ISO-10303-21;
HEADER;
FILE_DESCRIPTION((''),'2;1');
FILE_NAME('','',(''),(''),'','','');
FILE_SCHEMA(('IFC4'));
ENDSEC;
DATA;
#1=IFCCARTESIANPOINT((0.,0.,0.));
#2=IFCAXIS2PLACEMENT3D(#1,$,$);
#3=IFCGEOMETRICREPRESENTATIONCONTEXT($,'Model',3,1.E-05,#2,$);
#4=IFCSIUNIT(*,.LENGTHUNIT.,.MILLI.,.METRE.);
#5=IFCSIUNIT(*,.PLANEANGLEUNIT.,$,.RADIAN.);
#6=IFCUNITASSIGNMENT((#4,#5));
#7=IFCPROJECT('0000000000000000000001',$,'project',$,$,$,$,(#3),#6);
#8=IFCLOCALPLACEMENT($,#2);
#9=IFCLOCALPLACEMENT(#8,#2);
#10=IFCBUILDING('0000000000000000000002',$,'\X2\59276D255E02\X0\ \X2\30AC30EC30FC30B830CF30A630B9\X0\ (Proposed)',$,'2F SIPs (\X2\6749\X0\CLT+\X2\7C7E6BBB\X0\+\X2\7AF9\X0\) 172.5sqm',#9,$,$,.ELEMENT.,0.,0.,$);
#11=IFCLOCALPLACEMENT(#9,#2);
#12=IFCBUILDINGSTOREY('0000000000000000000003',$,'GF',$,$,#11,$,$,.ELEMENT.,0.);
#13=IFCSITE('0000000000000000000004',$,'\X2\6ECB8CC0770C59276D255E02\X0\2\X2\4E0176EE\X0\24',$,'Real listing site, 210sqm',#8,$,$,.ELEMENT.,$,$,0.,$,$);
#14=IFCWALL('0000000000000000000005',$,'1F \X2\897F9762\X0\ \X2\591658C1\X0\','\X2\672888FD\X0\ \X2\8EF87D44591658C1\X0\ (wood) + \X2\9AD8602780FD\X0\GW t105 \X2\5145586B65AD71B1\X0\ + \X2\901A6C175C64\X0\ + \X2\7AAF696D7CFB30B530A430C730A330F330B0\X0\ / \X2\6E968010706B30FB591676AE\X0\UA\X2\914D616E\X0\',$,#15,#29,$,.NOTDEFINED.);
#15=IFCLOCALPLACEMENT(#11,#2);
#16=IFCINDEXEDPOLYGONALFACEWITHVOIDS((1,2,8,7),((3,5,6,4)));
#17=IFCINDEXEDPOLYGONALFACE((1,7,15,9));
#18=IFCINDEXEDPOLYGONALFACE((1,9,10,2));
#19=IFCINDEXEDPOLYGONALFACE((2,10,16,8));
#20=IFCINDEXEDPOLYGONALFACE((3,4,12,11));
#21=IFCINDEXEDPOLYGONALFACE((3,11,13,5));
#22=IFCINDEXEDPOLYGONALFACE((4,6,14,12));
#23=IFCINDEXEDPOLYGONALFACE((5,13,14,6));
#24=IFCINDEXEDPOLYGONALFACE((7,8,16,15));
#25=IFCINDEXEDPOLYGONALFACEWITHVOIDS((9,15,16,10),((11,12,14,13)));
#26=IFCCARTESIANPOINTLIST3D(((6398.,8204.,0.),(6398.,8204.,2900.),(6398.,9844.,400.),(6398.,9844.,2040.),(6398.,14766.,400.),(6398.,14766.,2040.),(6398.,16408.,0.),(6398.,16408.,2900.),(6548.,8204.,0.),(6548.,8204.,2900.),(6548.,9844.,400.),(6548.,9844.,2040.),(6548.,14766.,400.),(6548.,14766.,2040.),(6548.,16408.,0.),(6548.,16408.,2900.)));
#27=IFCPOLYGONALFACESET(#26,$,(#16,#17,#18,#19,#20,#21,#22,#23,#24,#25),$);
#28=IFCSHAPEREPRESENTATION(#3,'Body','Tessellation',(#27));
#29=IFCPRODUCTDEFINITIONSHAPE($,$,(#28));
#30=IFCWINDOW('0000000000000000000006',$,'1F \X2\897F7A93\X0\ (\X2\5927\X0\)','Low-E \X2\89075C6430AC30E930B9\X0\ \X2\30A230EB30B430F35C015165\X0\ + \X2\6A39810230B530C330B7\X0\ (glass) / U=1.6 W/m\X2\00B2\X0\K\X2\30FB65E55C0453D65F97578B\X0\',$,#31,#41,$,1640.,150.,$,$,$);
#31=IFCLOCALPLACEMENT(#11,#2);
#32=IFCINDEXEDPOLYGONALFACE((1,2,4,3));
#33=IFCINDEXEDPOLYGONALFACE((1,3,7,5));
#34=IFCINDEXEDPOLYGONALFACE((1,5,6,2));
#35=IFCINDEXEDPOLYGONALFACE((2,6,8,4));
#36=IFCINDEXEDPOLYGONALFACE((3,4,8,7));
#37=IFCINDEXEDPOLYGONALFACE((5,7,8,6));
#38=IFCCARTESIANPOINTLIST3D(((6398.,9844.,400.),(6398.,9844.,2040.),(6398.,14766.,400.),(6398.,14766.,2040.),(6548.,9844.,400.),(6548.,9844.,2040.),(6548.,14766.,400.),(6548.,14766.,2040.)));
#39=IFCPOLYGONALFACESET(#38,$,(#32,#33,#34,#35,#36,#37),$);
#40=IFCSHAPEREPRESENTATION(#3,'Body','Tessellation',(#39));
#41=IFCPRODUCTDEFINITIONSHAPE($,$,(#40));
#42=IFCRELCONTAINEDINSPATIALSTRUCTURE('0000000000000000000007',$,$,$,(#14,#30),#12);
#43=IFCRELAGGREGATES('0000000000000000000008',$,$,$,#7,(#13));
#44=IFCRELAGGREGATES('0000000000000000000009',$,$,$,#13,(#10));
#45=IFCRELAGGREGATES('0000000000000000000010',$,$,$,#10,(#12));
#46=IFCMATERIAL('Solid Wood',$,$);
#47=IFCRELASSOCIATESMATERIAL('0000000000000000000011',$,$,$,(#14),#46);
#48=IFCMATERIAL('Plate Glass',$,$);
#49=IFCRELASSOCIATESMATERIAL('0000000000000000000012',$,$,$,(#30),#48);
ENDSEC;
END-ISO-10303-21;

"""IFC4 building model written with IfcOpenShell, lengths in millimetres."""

from ifc_helpers import new_model, si_unit, frame, frame_2d, origin, place, context, project, spatial, rectangle, extrude, material, element, fill, save


model = new_model("IFC4")

# Units and contexts
model_context = context("Model", 3, precision=1e-05, world=origin())
ifc_project = project(units=[si_unit("LENGTHUNIT", "METRE", prefix="MILLI"), si_unit("PLANEANGLEUNIT", "RADIAN")], contexts=[model_context])

# Site, building, storey
site_placement = place(None, origin())
site = spatial("IfcSite", under=ifc_project, at=site_placement, Name="滋賀県大津市2丁目24", ObjectType="Real listing site, 210sqm", CompositionType="ELEMENT", RefElevation=0.0)
building_placement = place(site_placement, origin())
building = spatial("IfcBuilding", under=site, at=building_placement, Name="大津市 ガレージハウス (Proposed)", ObjectType="2F SIPs (杉CLT+籾殻+竹) 172.5sqm", CompositionType="ELEMENT", ElevationOfRefHeight=0.0, ElevationOfTerrain=0.0)
storey_placement = place(building_placement, origin())
storey = spatial("IfcBuildingStorey", under=building, at=storey_placement, Name="GF", CompositionType="ELEMENT", Elevation=0.0)

# Shared definitions
ifc_material_1 = material(Name="Solid Wood")

# Shared definitions
ifc_material_2 = material(Name="Plate Glass")

# Wall, opening, window
wall_1_placement = place(storey_placement, frame((3199.0, 4102.0, 0.0)))
wall_1 = element("IfcWall", 1, at=wall_1_placement, inside=storey, material=ifc_material_1, Name="1F 西面 外壁", Description="木製 軸組外壁 (wood) + 高性能GW t105 充填断熱 + 通気層 + 窯業系サイディング / 準耐火・外皮UA配慮", PredefinedType="NOTDEFINED", context=model_context, shape_type="SweptSolid", body=[
    extrude(rectangle(XDim=150.0, YDim=8204.0, at=frame_2d((75.0, 4102.0))), frame((3199.0, 4102.0, 0.0)), (0.0, 0.0, 1.0), 2900.0),
])
opening_1_placement = place(storey_placement, frame((3199.0, 4922.0, 200.0)))
opening_1 = element("IfcOpeningElement", 2, at=opening_1_placement, cuts=wall_1, PredefinedType="NOTDEFINED", context=model_context, shape_type="SweptSolid", body=[
    extrude(rectangle(XDim=150.0, YDim=4922.0, at=frame_2d((75.0, 2461.0))), frame((3199.0, 4922.0, 200.0)), (0.0, 0.0, 1.0), 1640.0),
])
window_1_placement = place(storey_placement, frame((3199.0, 4922.0, 200.0)))
window_1 = element("IfcWindow", 3, at=window_1_placement, inside=storey, material=ifc_material_2, Name="1F 西窓 (大)", Description="Low-E 複層ガラス アルゴン封入 + 樹脂サッシ (glass) / U=1.6 W/m²K・日射取得型", OverallHeight=1640.0, OverallWidth=150.0, context=model_context, shape_type="SweptSolid", body=[
    extrude(rectangle(XDim=150.0, YDim=4922.0, at=frame_2d((75.0, 2461.0))), frame((3199.0, 4922.0, 200.0)), (0.0, 0.0, 1.0), 1640.0),
])
fill(opening_1, window_1)

save(model, "model.ifc")
